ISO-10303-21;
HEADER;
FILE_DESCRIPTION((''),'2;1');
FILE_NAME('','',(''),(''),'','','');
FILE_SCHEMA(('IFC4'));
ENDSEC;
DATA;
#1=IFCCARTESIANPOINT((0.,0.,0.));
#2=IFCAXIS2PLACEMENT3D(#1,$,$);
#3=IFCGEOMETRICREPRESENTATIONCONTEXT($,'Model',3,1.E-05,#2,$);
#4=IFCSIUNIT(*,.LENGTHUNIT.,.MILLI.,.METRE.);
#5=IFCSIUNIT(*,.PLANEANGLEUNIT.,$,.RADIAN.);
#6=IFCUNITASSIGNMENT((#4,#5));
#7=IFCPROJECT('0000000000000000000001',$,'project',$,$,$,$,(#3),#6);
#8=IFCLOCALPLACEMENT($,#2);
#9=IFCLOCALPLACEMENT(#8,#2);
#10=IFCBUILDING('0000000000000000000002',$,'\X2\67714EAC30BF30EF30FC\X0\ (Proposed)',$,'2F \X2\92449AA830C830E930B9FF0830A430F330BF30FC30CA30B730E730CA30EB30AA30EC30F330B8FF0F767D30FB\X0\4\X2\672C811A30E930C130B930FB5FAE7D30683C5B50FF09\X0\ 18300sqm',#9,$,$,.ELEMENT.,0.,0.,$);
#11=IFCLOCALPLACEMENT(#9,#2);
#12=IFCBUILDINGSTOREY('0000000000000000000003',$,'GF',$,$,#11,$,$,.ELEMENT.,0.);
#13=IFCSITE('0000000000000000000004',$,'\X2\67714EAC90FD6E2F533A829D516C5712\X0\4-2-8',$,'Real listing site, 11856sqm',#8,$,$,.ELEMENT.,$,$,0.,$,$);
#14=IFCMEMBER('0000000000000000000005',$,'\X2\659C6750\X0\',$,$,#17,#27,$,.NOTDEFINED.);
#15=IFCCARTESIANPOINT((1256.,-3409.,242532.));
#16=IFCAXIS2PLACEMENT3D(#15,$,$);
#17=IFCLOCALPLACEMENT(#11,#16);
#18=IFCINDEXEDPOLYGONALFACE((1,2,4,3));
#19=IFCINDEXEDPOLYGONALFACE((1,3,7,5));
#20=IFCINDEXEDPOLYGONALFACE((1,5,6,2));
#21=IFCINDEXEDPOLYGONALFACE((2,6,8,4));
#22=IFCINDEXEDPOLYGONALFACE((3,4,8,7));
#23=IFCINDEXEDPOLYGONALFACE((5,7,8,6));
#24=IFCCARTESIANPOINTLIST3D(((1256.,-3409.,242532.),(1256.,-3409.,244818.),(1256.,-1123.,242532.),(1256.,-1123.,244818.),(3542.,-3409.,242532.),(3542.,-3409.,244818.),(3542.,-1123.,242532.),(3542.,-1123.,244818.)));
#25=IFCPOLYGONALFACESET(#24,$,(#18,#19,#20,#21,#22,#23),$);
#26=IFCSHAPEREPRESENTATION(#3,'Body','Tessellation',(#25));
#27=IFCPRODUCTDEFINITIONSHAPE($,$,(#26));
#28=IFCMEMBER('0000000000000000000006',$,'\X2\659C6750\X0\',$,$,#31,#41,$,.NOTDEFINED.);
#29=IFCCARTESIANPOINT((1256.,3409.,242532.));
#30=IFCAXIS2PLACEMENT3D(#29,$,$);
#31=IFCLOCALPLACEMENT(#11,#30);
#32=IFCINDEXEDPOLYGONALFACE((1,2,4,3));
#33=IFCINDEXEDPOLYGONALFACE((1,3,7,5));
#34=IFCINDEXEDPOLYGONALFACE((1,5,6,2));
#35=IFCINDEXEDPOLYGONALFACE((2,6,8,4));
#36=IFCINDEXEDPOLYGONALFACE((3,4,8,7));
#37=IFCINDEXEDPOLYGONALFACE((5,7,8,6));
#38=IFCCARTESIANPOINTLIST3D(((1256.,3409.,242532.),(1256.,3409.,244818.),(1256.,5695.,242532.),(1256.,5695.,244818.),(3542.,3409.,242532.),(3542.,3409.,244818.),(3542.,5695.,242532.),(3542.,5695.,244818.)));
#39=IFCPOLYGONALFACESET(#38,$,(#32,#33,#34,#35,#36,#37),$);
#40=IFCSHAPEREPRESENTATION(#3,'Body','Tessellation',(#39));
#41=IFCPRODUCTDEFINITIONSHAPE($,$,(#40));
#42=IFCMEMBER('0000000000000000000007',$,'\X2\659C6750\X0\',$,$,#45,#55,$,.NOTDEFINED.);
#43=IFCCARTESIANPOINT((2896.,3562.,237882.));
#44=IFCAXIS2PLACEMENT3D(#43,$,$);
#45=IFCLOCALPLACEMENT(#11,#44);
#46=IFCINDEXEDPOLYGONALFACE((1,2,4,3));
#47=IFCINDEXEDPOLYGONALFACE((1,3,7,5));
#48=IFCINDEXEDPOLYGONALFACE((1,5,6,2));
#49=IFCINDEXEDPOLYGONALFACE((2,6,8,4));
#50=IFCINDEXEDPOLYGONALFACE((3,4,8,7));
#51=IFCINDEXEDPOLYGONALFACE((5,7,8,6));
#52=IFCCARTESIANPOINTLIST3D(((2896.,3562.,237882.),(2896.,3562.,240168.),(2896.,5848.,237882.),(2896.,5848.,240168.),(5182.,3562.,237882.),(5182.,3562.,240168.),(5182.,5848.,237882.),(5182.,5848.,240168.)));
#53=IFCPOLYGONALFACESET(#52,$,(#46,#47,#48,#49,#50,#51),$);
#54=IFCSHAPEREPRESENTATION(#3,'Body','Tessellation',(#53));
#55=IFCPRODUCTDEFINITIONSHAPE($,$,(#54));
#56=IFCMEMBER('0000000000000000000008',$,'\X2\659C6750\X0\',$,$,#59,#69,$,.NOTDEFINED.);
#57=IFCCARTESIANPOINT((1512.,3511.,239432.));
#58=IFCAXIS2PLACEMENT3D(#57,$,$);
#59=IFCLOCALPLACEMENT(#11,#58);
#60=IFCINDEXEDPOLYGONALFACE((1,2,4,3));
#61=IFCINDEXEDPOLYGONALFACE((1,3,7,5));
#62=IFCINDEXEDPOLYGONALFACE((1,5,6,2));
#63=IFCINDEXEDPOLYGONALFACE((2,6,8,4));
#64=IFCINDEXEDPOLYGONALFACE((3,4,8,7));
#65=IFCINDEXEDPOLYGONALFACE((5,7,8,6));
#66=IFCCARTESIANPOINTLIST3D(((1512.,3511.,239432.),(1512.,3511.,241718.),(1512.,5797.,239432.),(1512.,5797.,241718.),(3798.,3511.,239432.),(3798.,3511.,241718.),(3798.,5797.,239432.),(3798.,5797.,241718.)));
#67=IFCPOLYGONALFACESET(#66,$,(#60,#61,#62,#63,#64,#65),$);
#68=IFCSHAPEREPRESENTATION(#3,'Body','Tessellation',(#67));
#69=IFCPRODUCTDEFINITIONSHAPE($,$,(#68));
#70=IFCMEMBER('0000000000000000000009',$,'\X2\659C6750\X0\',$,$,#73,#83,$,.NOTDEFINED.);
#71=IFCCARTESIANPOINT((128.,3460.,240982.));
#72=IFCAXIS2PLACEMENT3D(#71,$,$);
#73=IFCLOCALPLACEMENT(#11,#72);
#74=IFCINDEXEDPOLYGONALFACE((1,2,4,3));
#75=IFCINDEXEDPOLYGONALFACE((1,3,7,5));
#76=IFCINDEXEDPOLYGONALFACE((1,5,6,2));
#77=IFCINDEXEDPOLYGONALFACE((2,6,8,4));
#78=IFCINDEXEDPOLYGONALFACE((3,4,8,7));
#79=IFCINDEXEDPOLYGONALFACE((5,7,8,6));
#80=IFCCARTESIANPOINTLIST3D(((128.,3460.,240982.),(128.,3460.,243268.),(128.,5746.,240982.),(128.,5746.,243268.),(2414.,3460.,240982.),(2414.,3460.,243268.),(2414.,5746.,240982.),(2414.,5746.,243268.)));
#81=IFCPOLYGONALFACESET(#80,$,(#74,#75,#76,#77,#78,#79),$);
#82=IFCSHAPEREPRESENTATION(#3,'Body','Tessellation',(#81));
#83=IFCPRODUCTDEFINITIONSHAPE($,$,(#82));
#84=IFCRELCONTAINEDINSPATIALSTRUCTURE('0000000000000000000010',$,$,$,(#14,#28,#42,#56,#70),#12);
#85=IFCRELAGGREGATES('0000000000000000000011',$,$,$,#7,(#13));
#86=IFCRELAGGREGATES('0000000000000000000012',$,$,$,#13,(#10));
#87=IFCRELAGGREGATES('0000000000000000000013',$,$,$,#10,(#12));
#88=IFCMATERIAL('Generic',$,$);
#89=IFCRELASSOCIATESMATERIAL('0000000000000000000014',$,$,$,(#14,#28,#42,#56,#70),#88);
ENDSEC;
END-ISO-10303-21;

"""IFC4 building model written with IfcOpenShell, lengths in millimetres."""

from ifc_helpers import new_model, si_unit, frame, frame_2d, origin, place, context, project, spatial, rectangle, extrude, material, element, save


model = new_model("IFC4")

# Units and contexts
model_context = context("Model", 3, precision=1e-05, world=origin())
ifc_project = project(units=[si_unit("LENGTHUNIT", "METRE", prefix="MILLI"), si_unit("PLANEANGLEUNIT", "RADIAN")], contexts=[model_context])

# Site, building, storey
site_placement = place(None, origin())
site = spatial("IfcSite", under=ifc_project, at=site_placement, Name="東京都港区芝公園4-2-8", ObjectType="Real listing site, 11856sqm", CompositionType="ELEMENT", RefElevation=0.0)
building_placement = place(site_placement, origin())
building = spatial("IfcBuilding", under=site, at=building_placement, Name="東京タワー (Proposed)", ObjectType="2F 鉄骨トラス（インターナショナルオレンジ／白・4本脚ラチス・微細格子） 18300sqm", CompositionType="ELEMENT", ElevationOfRefHeight=0.0, ElevationOfTerrain=0.0)
storey_placement = place(building_placement, origin())
storey = spatial("IfcBuildingStorey", under=building, at=storey_placement, Name="GF", CompositionType="ELEMENT", Elevation=0.0)

# Shared definitions
ifc_material = material(Name="Generic")

# Members
member_1_placement = place(storey_placement, frame((1256.0, -3409.0, 242532.0)))
element("IfcMember", 1, at=member_1_placement, inside=storey, material=ifc_material, Name="斜材", PredefinedType="NOTDEFINED", context=model_context, shape_type="SweptSolid", body=[
    extrude(rectangle(XDim=2286.0, YDim=2286.0, at=frame_2d((1143.0, 1143.0))), frame((1256.0, -3409.0, 242532.0)), (0.0, 0.0, 1.0), 2286.0),
])
member_2_placement = place(storey_placement, frame((1256.0, 3409.0, 242532.0)))
element("IfcMember", 2, at=member_2_placement, inside=storey, material=ifc_material, Name="斜材", PredefinedType="NOTDEFINED", context=model_context, shape_type="SweptSolid", body=[
    extrude(rectangle(XDim=2286.0, YDim=2286.0, at=frame_2d((1143.0, 1143.0))), frame((1256.0, 3409.0, 242532.0)), (0.0, 0.0, 1.0), 2286.0),
])
member_3_placement = place(storey_placement, frame((2896.0, 3562.0, 237882.0)))
element("IfcMember", 3, at=member_3_placement, inside=storey, material=ifc_material, Name="斜材", PredefinedType="NOTDEFINED", context=model_context, shape_type="SweptSolid", body=[
    extrude(rectangle(XDim=2286.0, YDim=2286.0, at=frame_2d((1143.0, 1143.0))), frame((2896.0, 3562.0, 237882.0)), (0.0, 0.0, 1.0), 2286.0),
])
member_4_placement = place(storey_placement, frame((1512.0, 3511.0, 239432.0)))
element("IfcMember", 4, at=member_4_placement, inside=storey, material=ifc_material, Name="斜材", PredefinedType="NOTDEFINED", context=model_context, shape_type="SweptSolid", body=[
    extrude(rectangle(XDim=2286.0, YDim=2286.0, at=frame_2d((1143.0, 1143.0))), frame((1512.0, 3511.0, 239432.0)), (0.0, 0.0, 1.0), 2286.0),
])
member_5_placement = place(storey_placement, frame((128.0, 3460.0, 240982.0)))
element("IfcMember", 5, at=member_5_placement, inside=storey, material=ifc_material, Name="斜材", PredefinedType="NOTDEFINED", context=model_context, shape_type="SweptSolid", body=[
    extrude(rectangle(XDim=2286.0, YDim=2286.0, at=frame_2d((1143.0, 1143.0))), frame((128.0, 3460.0, 240982.0)), (0.0, 0.0, 1.0), 2286.0),
])

save(model, "model.ifc")
